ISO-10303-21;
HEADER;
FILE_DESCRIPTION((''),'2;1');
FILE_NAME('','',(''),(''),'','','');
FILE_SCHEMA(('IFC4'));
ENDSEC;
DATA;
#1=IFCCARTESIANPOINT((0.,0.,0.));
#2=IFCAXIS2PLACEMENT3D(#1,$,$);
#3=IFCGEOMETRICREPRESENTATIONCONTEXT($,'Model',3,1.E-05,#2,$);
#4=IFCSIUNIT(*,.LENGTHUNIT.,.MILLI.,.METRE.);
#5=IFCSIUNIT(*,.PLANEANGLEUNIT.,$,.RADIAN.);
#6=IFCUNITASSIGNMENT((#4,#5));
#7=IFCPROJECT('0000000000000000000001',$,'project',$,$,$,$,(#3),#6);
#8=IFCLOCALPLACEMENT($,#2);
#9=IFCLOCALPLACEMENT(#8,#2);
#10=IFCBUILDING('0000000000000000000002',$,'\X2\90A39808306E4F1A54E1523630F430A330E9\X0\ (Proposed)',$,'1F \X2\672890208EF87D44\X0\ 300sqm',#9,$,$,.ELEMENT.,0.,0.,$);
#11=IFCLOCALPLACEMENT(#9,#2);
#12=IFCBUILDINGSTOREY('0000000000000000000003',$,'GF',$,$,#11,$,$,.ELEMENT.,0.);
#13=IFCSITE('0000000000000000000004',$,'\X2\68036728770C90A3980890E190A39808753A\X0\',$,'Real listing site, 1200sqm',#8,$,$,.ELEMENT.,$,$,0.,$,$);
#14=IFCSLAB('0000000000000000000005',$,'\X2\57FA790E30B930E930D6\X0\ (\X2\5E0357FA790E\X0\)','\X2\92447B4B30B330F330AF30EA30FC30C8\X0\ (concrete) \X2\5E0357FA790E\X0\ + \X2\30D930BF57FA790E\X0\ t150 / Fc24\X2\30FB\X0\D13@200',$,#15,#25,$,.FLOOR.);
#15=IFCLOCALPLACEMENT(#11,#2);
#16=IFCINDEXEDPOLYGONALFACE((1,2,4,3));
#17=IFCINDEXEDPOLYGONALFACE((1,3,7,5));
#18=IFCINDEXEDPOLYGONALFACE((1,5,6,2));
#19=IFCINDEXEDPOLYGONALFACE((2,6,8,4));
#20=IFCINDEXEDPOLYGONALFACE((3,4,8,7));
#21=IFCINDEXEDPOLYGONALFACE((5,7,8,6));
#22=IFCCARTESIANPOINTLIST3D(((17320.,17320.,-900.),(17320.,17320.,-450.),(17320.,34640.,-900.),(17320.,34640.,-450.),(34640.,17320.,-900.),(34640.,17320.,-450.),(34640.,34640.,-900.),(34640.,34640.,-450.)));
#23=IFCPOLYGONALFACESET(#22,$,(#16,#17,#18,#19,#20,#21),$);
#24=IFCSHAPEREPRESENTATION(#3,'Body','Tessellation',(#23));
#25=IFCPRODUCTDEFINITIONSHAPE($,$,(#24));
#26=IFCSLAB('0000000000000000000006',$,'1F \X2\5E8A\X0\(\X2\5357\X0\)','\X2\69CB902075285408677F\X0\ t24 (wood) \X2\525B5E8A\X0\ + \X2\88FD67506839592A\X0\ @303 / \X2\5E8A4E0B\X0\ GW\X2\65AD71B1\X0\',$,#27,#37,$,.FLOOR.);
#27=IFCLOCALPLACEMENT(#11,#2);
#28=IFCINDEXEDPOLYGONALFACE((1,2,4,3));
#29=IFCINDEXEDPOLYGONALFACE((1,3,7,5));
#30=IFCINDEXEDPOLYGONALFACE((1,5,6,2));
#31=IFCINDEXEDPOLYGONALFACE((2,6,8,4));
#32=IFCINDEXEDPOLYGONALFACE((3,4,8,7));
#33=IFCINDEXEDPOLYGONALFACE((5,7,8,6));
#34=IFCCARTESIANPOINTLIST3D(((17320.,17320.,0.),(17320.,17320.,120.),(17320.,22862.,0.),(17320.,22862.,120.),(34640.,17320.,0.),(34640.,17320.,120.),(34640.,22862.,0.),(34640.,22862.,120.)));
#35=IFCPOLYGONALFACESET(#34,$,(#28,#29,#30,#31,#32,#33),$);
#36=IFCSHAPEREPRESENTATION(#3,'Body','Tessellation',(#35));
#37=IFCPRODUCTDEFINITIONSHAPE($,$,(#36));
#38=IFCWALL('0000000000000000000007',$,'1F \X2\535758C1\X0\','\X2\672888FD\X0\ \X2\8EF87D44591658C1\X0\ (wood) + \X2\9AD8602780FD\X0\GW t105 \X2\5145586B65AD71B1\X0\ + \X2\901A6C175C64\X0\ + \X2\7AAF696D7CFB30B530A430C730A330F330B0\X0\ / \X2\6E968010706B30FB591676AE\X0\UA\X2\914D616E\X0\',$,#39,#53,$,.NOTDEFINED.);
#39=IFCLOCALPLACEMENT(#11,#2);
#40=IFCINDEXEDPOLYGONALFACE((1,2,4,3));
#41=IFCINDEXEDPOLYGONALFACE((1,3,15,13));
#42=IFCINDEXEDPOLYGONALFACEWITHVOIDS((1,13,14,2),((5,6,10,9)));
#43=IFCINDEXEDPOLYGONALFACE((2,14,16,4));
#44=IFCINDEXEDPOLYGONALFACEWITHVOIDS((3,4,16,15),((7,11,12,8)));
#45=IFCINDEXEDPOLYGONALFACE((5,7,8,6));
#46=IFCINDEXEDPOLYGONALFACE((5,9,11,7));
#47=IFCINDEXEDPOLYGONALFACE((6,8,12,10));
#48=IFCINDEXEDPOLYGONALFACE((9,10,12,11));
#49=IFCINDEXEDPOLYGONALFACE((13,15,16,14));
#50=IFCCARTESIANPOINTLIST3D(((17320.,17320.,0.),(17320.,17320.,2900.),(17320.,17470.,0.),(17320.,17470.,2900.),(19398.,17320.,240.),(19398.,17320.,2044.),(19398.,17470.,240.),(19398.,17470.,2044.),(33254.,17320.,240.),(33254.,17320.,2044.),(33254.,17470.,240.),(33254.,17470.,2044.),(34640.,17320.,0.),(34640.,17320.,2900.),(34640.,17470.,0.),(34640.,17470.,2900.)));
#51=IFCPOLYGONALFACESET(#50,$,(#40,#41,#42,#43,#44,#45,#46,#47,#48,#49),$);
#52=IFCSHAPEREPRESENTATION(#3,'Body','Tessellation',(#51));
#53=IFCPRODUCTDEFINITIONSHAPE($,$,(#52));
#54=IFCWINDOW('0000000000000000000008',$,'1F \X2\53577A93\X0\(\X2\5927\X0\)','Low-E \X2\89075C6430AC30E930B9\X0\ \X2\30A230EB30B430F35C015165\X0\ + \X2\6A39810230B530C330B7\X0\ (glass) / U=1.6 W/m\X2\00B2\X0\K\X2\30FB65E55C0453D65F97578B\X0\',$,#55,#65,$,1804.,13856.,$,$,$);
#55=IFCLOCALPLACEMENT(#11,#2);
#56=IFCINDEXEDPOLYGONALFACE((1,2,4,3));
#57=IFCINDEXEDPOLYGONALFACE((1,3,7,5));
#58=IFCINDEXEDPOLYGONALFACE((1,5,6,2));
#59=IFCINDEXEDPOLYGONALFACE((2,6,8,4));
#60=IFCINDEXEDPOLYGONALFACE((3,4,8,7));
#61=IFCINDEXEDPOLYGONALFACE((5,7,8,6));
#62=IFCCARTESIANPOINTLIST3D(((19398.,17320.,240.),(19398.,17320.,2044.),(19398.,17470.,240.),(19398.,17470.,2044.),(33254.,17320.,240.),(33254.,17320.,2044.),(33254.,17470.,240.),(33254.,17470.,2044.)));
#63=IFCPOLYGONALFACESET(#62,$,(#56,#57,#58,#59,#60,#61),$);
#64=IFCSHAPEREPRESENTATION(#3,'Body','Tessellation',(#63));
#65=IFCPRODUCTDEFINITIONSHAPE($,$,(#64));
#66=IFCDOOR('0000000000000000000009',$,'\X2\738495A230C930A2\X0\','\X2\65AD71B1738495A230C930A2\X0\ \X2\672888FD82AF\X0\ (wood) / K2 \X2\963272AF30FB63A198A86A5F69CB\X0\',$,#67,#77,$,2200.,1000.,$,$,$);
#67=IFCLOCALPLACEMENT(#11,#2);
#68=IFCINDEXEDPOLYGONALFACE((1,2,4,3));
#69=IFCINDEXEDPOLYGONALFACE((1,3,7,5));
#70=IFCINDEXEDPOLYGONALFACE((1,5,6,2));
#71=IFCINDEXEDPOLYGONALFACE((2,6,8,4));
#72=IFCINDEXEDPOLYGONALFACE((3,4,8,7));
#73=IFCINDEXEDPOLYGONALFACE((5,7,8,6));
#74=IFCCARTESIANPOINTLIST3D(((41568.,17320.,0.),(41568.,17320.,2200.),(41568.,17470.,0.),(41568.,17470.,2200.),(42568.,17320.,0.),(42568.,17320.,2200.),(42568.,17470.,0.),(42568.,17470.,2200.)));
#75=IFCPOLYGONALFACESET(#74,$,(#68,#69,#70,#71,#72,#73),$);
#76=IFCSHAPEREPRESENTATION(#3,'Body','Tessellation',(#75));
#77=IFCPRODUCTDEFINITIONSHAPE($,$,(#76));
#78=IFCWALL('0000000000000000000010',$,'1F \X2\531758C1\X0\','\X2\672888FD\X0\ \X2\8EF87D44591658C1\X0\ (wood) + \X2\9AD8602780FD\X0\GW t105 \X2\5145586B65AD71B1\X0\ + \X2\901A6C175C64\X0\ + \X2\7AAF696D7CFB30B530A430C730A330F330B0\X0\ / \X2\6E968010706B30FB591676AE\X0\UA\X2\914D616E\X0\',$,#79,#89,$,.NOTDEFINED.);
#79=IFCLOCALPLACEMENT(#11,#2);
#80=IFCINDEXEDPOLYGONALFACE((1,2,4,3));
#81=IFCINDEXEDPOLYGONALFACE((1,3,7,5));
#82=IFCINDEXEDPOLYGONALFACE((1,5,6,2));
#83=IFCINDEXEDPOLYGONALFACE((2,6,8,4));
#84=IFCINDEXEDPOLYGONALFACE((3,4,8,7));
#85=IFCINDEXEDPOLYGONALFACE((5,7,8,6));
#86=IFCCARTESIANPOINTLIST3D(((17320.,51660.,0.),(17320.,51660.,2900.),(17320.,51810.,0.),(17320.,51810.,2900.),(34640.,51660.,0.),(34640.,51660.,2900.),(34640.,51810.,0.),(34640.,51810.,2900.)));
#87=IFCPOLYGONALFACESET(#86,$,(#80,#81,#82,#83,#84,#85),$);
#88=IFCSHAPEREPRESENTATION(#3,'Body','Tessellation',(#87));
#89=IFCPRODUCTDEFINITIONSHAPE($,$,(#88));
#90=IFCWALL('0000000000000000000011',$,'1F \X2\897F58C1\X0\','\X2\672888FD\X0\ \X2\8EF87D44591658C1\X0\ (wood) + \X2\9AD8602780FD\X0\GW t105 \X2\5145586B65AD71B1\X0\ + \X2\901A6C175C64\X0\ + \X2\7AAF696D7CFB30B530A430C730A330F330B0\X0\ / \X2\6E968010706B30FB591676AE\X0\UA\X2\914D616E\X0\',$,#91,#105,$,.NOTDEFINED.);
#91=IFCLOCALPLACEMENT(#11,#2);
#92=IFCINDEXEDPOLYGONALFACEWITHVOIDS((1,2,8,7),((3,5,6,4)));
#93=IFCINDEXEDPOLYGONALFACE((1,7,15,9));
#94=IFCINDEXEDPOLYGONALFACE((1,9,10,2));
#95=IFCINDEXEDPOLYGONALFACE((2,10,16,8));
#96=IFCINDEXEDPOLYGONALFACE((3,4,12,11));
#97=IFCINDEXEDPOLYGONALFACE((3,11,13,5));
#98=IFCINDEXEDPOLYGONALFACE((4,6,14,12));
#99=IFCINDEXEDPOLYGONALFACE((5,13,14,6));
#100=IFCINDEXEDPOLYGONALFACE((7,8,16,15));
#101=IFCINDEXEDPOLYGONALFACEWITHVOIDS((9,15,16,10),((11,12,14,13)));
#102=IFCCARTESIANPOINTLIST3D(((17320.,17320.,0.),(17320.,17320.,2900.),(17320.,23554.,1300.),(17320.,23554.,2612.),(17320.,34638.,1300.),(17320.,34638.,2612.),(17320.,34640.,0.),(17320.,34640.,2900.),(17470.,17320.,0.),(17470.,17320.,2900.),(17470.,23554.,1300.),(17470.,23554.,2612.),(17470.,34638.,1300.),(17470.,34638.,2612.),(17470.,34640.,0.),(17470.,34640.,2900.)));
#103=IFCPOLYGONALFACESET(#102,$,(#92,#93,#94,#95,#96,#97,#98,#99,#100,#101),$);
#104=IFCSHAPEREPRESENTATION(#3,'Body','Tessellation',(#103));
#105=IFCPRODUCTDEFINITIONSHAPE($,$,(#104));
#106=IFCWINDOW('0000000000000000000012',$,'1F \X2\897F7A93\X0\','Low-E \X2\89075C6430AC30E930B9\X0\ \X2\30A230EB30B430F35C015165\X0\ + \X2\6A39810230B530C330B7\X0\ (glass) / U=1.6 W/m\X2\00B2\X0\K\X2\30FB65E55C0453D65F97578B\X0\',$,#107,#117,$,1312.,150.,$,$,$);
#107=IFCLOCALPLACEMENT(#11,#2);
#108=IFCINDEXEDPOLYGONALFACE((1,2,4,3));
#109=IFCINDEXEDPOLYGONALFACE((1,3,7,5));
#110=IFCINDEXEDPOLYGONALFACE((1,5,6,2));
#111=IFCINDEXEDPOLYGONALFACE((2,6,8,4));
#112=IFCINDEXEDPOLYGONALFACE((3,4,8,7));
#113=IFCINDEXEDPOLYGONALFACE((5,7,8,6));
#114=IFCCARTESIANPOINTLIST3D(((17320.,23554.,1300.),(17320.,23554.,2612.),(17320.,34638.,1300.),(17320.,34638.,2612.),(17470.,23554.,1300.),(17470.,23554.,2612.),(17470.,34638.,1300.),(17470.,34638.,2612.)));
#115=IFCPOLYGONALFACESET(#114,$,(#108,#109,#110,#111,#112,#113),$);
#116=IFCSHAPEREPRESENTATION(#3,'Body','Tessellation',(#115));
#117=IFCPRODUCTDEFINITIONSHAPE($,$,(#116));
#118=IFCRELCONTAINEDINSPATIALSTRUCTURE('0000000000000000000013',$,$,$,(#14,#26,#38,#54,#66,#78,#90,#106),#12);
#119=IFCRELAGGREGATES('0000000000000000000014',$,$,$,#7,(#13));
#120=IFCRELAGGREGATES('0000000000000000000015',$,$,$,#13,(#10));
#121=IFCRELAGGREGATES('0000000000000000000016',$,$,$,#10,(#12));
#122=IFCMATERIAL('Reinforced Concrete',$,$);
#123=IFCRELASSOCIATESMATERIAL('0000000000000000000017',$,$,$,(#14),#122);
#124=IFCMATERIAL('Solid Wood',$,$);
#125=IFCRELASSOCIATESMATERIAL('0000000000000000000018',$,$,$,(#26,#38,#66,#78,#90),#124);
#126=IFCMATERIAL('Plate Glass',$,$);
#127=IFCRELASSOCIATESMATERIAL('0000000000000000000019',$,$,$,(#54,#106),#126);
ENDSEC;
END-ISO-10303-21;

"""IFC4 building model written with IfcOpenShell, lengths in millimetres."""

from ifc_helpers import new_model, si_unit, frame, frame_2d, origin, place, context, project, spatial, rectangle, extrude, material, element, fill, save


model = new_model("IFC4")

# Units and contexts
model_context = context("Model", 3, precision=1e-05, world=origin())
ifc_project = project(units=[si_unit("LENGTHUNIT", "METRE", prefix="MILLI"), si_unit("PLANEANGLEUNIT", "RADIAN")], contexts=[model_context])

# Site, building, storey
site_placement = place(None, origin())
site = spatial("IfcSite", under=ifc_project, at=site_placement, Name="栃木県那須郡那須町", ObjectType="Real listing site, 1200sqm", CompositionType="ELEMENT", RefElevation=0.0)
building_placement = place(site_placement, origin())
building = spatial("IfcBuilding", under=site, at=building_placement, Name="那須の会員制ヴィラ (Proposed)", ObjectType="1F 木造軸組 300sqm", CompositionType="ELEMENT", ElevationOfRefHeight=0.0, ElevationOfTerrain=0.0)
storey_placement = place(building_placement, origin())
storey = spatial("IfcBuildingStorey", under=building, at=storey_placement, Name="GF", CompositionType="ELEMENT", Elevation=0.0)

# Slabs
ifc_material_1 = material(Name="Reinforced Concrete")
slab_1_placement = place(storey_placement, frame((8660.0, 8660.0, -450.0)))
element("IfcSlab", 1, at=slab_1_placement, inside=storey, material=ifc_material_1, Name="基礎スラブ (布基礎)", Description="鉄筋コンクリート (concrete) 布基礎 + ベタ基礎 t150 / Fc24・D13@200", PredefinedType="FLOOR", context=model_context, shape_type="SweptSolid", body=[
    extrude(rectangle(XDim=17320.0, YDim=17320.0, at=frame_2d((8660.0, 8660.0))), frame((8660.0, 8660.0, -450.0)), (0.0, 0.0, 1.0), 450.0),
])
ifc_material_2 = material(Name="Solid Wood")
slab_2_placement = place(storey_placement, frame((8660.0, 8660.0, 0.0)))
element("IfcSlab", 2, at=slab_2_placement, inside=storey, material=ifc_material_2, Name="1F 床(南)", Description="構造用合板 t24 (wood) 剛床 + 製材根太 @303 / 床下 GW断熱", PredefinedType="FLOOR", context=model_context, shape_type="SweptSolid", body=[
    extrude(rectangle(XDim=17320.0, YDim=5542.0, at=frame_2d((8660.0, 2771.0))), frame((8660.0, 8660.0, 0.0)), (0.0, 0.0, 1.0), 120.0),
])

# Wall, openings, window, door
wall_1_placement = place(storey_placement, frame((8660.0, 8660.0, 0.0)))
wall_1 = element("IfcWall", 3, at=wall_1_placement, inside=storey, material=ifc_material_2, Name="1F 南壁", Description="木製 軸組外壁 (wood) + 高性能GW t105 充填断熱 + 通気層 + 窯業系サイディング / 準耐火・外皮UA配慮", PredefinedType="NOTDEFINED", context=model_context, shape_type="SweptSolid", body=[
    extrude(rectangle(XDim=17320.0, YDim=150.0, at=frame_2d((8660.0, 75.0))), frame((8660.0, 8660.0, 0.0)), (0.0, 0.0, 1.0), 2900.0),
])
opening_1_placement = place(storey_placement, frame((9699.0, 8660.0, 120.0)))
opening_1 = element("IfcOpeningElement", 4, at=opening_1_placement, cuts=wall_1, PredefinedType="NOTDEFINED", context=model_context, shape_type="SweptSolid", body=[
    extrude(rectangle(XDim=13856.0, YDim=150.0, at=frame_2d((6928.0, 75.0))), frame((9699.0, 8660.0, 120.0)), (0.0, 0.0, 1.0), 1804.0),
])
opening_2_placement = place(storey_placement, frame((20784.0, 8660.0, 0.0)))
opening_2 = element("IfcOpeningElement", 5, at=opening_2_placement, cuts=wall_1, PredefinedType="NOTDEFINED", context=model_context, shape_type="SweptSolid", body=[
    extrude(rectangle(XDim=1000.0, YDim=150.0, at=frame_2d((500.0, 75.0))), frame((20784.0, 8660.0, 0.0)), (0.0, 0.0, 1.0), 2200.0),
])
ifc_material_3 = material(Name="Plate Glass")
window_1_placement = place(storey_placement, frame((9699.0, 8660.0, 120.0)))
window_1 = element("IfcWindow", 6, at=window_1_placement, inside=storey, material=ifc_material_3, Name="1F 南窓(大)", Description="Low-E 複層ガラス アルゴン封入 + 樹脂サッシ (glass) / U=1.6 W/m²K・日射取得型", OverallHeight=1804.0, OverallWidth=13856.0, context=model_context, shape_type="SweptSolid", body=[
    extrude(rectangle(XDim=13856.0, YDim=150.0, at=frame_2d((6928.0, 75.0))), frame((9699.0, 8660.0, 120.0)), (0.0, 0.0, 1.0), 1804.0),
])
fill(opening_1, window_1)
door_placement = place(storey_placement, frame((20784.0, 8660.0, 0.0)))
door = element("IfcDoor", 7, at=door_placement, inside=storey, material=ifc_material_2, Name="玄関ドア", Description="断熱玄関ドア 木製芯 (wood) / K2 防犯・採風機構", OverallHeight=2200.0, OverallWidth=1000.0, context=model_context, shape_type="SweptSolid", body=[
    extrude(rectangle(XDim=1000.0, YDim=150.0, at=frame_2d((500.0, 75.0))), frame((20784.0, 8660.0, 0.0)), (0.0, 0.0, 1.0), 2200.0),
])
fill(opening_2, door)

# Wall
wall_2_placement = place(storey_placement, frame((8660.0, 25830.0, 0.0)))
element("IfcWall", 8, at=wall_2_placement, inside=storey, material=ifc_material_2, Name="1F 北壁", Description="木製 軸組外壁 (wood) + 高性能GW t105 充填断熱 + 通気層 + 窯業系サイディング / 準耐火・外皮UA配慮", PredefinedType="NOTDEFINED", context=model_context, shape_type="SweptSolid", body=[
    extrude(rectangle(XDim=17320.0, YDim=150.0, at=frame_2d((8660.0, 75.0))), frame((8660.0, 25830.0, 0.0)), (0.0, 0.0, 1.0), 2900.0),
])

# Wall, opening, window
wall_3_placement = place(storey_placement, frame((8660.0, 8660.0, 0.0)))
wall_3 = element("IfcWall", 9, at=wall_3_placement, inside=storey, material=ifc_material_2, Name="1F 西壁", Description="木製 軸組外壁 (wood) + 高性能GW t105 充填断熱 + 通気層 + 窯業系サイディング / 準耐火・外皮UA配慮", PredefinedType="NOTDEFINED", context=model_context, shape_type="SweptSolid", body=[
    extrude(rectangle(XDim=150.0, YDim=17320.0, at=frame_2d((75.0, 8660.0))), frame((8660.0, 8660.0, 0.0)), (0.0, 0.0, 1.0), 2900.0),
])
opening_3_placement = place(storey_placement, frame((8660.0, 11777.0, 650.0)))
opening_3 = element("IfcOpeningElement", 10, at=opening_3_placement, cuts=wall_3, PredefinedType="NOTDEFINED", context=model_context, shape_type="SweptSolid", body=[
    extrude(rectangle(XDim=150.0, YDim=11084.0, at=frame_2d((75.0, 5542.0))), frame((8660.0, 11777.0, 650.0)), (0.0, 0.0, 1.0), 1312.0),
])
window_2_placement = place(storey_placement, frame((8660.0, 11777.0, 650.0)))
window_2 = element("IfcWindow", 11, at=window_2_placement, inside=storey, material=ifc_material_3, Name="1F 西窓", Description="Low-E 複層ガラス アルゴン封入 + 樹脂サッシ (glass) / U=1.6 W/m²K・日射取得型", OverallHeight=1312.0, OverallWidth=150.0, context=model_context, shape_type="SweptSolid", body=[
    extrude(rectangle(XDim=150.0, YDim=11084.0, at=frame_2d((75.0, 5542.0))), frame((8660.0, 11777.0, 650.0)), (0.0, 0.0, 1.0), 1312.0),
])
fill(opening_3, window_2)

save(model, "model.ifc")
